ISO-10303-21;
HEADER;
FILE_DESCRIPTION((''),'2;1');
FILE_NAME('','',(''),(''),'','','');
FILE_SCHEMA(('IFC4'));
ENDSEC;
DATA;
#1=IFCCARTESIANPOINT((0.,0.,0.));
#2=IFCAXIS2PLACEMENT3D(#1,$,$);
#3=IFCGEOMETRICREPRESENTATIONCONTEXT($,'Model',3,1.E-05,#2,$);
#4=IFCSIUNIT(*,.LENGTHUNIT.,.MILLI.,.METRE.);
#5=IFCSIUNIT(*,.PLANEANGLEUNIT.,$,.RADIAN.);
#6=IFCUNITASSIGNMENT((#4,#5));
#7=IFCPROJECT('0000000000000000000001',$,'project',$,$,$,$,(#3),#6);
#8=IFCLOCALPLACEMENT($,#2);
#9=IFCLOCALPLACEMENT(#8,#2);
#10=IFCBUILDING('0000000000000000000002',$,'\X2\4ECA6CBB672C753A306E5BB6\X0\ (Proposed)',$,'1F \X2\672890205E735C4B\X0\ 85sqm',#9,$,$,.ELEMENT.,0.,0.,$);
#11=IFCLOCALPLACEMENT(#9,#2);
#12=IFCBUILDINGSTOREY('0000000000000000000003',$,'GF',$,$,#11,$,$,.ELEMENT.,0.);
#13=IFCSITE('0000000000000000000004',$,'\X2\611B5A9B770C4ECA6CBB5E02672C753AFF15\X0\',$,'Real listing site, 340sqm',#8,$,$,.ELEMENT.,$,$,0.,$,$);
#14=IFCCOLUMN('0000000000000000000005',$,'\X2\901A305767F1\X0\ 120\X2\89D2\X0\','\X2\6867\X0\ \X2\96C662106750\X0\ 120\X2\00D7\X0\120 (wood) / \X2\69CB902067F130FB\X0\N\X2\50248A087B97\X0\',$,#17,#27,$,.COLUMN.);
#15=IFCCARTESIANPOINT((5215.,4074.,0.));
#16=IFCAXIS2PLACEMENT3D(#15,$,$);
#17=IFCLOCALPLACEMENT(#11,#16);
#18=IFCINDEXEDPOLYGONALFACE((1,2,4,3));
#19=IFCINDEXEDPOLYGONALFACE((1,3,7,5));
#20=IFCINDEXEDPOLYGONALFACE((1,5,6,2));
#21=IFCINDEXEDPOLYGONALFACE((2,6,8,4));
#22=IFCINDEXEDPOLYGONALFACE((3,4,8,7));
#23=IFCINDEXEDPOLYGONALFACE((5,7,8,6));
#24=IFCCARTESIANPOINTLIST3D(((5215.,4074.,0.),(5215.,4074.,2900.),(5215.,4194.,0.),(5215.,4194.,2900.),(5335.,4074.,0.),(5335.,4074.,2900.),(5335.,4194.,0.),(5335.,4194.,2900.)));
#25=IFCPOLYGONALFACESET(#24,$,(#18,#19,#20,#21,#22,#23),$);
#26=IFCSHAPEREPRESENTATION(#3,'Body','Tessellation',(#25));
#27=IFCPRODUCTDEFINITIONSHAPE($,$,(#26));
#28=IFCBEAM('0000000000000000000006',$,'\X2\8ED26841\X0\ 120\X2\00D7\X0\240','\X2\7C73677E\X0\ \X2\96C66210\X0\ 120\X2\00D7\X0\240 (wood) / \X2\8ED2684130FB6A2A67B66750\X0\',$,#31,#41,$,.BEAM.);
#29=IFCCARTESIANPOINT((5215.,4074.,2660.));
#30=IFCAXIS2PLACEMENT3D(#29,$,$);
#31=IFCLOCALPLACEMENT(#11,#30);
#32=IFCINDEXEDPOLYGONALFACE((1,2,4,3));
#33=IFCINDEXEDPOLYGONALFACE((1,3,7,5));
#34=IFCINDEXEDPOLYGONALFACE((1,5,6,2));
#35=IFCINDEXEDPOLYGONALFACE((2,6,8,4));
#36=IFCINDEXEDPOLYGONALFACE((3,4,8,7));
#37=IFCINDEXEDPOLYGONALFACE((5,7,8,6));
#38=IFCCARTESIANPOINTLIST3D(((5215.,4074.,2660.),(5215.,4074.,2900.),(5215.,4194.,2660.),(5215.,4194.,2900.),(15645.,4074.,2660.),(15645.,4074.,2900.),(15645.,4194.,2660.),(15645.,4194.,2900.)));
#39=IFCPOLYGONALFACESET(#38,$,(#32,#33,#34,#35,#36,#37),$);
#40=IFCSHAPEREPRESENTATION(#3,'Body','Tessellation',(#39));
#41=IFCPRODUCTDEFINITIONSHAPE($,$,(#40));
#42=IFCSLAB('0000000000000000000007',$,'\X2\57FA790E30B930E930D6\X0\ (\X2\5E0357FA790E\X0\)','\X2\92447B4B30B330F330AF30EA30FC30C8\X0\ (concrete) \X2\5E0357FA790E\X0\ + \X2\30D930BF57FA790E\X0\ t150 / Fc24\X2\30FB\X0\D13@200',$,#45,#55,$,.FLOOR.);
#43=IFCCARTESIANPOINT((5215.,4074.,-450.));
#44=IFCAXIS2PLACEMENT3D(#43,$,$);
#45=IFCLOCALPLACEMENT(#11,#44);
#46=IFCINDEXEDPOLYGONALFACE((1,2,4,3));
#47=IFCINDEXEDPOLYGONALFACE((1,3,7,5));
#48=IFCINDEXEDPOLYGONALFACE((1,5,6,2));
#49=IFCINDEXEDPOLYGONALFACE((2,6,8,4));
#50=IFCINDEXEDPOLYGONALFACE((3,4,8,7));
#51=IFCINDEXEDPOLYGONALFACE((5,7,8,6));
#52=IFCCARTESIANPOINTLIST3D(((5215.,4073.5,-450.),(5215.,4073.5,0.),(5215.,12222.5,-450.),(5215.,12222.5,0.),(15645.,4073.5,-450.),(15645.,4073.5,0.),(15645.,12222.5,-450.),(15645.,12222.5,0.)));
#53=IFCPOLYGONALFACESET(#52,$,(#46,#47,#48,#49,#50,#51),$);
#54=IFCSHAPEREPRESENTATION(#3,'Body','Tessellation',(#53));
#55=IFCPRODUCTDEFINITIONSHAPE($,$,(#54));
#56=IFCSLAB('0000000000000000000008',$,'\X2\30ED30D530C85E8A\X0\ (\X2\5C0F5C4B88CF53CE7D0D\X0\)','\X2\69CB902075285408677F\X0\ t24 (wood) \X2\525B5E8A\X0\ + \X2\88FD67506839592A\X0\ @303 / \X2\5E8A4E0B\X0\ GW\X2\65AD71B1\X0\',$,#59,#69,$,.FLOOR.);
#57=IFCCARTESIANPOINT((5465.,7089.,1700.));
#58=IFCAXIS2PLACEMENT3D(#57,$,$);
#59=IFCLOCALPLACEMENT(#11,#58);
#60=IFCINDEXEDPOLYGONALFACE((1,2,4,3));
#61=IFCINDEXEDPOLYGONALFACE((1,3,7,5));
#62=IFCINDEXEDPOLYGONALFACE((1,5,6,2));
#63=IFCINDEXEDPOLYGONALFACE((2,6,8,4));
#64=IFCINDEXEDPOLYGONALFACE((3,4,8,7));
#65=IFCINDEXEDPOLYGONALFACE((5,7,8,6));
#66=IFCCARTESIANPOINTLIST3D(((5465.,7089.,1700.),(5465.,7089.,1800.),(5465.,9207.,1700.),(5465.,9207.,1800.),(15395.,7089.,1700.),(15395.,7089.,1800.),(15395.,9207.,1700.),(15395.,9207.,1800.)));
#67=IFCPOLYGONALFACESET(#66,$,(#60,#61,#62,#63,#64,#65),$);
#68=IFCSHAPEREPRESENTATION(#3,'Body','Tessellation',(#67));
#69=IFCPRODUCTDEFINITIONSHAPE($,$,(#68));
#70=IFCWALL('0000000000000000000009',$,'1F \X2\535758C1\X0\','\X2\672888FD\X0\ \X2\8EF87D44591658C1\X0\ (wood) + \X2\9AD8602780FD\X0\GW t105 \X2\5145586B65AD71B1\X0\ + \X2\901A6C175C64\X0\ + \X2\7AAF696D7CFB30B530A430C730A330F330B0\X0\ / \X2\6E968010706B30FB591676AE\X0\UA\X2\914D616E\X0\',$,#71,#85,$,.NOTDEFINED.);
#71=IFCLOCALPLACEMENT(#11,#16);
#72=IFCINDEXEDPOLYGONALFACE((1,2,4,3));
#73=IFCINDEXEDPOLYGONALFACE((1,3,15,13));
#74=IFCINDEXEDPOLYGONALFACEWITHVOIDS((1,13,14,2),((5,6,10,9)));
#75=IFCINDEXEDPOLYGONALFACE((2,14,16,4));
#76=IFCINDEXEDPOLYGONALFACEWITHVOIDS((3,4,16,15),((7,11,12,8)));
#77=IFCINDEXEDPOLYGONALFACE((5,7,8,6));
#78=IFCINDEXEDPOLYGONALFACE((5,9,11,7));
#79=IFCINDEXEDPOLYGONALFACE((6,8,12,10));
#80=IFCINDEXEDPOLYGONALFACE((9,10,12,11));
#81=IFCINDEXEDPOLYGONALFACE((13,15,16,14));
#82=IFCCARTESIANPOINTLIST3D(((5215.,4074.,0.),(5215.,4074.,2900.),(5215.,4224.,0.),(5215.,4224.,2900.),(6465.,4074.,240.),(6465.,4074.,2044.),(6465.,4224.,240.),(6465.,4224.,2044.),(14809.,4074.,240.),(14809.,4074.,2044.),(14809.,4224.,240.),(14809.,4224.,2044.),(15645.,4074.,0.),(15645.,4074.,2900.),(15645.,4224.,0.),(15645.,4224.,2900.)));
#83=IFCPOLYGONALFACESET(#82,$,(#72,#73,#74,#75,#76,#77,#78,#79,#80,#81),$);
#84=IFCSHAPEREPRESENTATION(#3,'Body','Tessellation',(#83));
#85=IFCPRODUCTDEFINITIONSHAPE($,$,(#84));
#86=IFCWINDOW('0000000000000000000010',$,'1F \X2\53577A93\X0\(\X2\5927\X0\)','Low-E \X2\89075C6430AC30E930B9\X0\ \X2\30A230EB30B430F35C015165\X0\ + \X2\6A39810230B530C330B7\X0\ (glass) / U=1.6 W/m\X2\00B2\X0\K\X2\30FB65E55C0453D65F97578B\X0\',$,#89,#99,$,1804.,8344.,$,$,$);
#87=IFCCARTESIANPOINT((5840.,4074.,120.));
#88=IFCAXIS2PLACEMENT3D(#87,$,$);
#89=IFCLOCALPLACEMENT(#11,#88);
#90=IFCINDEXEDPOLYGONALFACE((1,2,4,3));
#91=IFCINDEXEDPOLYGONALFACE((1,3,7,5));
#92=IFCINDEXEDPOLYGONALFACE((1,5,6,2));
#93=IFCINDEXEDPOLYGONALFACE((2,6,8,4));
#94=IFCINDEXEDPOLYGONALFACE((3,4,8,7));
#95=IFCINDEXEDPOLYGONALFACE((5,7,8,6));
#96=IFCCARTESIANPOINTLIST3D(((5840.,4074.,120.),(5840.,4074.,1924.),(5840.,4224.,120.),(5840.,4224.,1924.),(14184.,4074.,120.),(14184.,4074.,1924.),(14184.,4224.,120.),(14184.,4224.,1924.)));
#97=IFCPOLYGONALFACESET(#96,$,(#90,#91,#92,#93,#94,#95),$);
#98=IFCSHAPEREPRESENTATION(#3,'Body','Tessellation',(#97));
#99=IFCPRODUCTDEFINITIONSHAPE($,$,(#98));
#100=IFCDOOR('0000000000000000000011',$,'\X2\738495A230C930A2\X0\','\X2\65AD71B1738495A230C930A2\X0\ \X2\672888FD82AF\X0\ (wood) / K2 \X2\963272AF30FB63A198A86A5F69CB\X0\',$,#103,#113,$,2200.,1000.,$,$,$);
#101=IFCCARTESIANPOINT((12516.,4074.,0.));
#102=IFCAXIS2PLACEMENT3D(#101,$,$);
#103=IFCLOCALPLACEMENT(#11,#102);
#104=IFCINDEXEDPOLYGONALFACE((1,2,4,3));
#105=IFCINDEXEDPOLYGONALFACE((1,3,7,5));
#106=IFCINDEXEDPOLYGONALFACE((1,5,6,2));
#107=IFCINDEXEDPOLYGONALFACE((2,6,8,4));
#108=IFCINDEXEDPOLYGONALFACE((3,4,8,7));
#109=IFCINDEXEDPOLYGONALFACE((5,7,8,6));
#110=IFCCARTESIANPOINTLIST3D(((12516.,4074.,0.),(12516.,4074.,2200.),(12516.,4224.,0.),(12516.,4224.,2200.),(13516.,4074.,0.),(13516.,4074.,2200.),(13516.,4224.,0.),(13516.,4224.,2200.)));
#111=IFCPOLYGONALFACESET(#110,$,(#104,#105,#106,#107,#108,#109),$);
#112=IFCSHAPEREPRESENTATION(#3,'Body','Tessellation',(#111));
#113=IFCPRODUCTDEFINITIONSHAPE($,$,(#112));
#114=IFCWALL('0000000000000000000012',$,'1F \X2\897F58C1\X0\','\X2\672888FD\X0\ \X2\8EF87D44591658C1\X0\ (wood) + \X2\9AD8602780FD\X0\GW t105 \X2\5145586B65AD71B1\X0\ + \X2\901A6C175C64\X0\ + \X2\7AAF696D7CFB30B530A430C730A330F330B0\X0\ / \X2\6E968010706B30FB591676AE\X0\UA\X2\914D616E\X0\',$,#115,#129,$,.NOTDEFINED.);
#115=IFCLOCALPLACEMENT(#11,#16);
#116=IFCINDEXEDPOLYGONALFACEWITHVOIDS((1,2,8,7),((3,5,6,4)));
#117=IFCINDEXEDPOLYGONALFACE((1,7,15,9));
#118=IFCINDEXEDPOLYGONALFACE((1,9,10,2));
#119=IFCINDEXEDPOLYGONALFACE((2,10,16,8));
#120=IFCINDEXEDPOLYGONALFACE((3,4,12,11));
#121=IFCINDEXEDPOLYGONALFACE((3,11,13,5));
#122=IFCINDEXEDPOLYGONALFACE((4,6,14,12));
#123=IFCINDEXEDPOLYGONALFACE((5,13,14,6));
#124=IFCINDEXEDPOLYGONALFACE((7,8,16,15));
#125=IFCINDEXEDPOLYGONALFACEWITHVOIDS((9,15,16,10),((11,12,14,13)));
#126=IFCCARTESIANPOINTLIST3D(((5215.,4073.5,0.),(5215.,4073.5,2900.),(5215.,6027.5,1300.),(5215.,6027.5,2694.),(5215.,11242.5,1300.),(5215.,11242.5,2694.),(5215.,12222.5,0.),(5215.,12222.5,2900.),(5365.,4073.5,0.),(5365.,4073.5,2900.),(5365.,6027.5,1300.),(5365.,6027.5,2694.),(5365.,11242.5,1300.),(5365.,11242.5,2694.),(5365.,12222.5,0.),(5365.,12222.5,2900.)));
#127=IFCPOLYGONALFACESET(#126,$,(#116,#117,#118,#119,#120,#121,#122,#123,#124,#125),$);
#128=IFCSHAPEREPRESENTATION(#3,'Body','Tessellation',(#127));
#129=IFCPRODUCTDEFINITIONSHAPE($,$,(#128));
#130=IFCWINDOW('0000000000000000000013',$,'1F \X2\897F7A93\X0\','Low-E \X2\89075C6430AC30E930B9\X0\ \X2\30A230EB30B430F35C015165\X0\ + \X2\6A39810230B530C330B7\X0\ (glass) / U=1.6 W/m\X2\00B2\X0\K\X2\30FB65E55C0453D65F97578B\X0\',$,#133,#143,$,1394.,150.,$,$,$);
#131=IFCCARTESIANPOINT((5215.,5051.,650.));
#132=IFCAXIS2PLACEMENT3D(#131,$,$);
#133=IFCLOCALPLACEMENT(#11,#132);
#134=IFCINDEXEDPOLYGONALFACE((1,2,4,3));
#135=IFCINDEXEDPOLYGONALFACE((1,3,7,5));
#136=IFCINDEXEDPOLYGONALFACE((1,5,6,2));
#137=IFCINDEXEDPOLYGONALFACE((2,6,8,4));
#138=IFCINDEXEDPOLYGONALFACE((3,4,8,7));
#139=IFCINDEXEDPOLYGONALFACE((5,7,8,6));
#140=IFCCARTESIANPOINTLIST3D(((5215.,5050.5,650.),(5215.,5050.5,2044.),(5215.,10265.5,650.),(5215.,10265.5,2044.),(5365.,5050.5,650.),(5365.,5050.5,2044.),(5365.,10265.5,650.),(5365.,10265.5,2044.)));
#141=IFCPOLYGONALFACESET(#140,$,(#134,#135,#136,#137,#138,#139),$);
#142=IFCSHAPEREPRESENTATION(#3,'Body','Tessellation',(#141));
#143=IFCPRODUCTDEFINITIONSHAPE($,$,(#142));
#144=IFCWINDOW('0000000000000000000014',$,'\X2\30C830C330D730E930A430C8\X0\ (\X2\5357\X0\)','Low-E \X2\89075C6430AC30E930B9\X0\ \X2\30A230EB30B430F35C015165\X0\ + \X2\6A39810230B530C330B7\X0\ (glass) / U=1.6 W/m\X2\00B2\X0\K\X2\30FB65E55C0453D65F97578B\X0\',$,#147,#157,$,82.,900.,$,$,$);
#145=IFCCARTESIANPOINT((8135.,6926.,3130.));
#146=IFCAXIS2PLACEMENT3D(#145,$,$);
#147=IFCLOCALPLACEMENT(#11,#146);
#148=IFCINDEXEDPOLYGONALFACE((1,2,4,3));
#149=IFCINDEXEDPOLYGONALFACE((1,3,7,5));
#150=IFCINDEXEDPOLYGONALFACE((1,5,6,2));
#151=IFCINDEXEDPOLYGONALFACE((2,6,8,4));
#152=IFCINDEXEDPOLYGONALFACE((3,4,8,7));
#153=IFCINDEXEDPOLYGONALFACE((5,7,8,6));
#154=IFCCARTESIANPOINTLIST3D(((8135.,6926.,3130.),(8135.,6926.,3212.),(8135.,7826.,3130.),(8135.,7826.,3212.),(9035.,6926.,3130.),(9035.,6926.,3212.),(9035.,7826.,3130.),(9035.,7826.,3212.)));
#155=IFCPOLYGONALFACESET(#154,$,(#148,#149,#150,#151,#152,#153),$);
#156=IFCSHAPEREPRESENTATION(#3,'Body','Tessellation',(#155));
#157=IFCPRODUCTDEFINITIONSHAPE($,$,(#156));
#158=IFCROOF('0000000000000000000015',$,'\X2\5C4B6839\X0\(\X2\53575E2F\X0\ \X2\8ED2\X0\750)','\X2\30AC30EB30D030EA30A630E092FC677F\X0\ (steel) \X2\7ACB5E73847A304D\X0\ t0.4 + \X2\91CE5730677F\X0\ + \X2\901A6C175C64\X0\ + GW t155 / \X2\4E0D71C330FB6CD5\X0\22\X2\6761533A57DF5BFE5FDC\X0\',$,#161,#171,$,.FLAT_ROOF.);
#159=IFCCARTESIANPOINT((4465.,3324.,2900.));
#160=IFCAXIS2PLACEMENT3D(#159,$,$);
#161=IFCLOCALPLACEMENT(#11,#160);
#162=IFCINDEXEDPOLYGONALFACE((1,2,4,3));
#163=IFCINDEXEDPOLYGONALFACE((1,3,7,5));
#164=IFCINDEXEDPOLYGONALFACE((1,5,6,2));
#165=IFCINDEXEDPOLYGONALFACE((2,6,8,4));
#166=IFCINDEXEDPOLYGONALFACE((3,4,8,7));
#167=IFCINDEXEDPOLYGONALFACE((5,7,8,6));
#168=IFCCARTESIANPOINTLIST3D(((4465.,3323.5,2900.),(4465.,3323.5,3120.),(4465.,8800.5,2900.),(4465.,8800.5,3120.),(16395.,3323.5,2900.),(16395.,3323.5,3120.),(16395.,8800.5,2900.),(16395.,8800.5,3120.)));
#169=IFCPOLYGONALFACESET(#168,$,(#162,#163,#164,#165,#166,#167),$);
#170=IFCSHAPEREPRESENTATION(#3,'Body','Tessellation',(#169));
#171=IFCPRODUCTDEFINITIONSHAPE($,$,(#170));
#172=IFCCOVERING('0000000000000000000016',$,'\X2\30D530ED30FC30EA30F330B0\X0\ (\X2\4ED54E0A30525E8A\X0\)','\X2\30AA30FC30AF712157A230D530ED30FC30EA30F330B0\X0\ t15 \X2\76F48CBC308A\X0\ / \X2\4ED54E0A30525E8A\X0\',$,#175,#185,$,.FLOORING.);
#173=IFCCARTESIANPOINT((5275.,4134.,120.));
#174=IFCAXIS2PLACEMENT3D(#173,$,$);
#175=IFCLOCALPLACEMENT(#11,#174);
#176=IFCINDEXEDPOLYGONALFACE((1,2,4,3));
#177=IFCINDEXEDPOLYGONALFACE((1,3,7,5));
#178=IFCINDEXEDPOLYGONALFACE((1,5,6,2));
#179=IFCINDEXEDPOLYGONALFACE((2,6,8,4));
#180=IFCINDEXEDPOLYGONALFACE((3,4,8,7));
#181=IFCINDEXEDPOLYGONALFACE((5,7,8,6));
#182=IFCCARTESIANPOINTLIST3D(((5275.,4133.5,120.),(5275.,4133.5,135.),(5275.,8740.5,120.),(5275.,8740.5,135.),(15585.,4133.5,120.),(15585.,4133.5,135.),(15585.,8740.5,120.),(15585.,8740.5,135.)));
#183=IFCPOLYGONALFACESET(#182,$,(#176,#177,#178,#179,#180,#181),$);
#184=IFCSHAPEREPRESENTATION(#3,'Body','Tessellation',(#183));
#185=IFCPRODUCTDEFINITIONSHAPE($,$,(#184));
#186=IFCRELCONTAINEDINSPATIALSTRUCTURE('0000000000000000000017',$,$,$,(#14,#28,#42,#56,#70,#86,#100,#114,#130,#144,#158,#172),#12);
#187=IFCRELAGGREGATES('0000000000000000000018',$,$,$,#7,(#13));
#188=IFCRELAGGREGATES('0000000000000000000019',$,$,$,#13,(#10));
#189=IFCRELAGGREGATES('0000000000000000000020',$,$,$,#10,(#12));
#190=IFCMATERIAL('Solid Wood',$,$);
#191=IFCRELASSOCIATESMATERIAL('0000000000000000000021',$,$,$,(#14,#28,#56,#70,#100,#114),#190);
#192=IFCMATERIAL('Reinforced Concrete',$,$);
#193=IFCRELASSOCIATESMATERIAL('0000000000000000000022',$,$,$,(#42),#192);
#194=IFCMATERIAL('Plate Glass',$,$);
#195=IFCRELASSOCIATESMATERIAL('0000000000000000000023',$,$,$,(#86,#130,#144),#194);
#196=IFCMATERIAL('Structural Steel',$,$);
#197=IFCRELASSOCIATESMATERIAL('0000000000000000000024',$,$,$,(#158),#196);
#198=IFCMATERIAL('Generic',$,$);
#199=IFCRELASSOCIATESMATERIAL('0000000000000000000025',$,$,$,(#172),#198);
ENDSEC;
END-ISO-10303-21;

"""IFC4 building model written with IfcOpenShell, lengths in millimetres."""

from ifc_helpers import new_model, si_unit, frame, frame_2d, origin, place, context, project, spatial, rectangle, extrude, material, element, fill, save


model = new_model("IFC4")

# Units and contexts
model_context = context("Model", 3, precision=1e-05, world=origin())
ifc_project = project(units=[si_unit("LENGTHUNIT", "METRE", prefix="MILLI"), si_unit("PLANEANGLEUNIT", "RADIAN")], contexts=[model_context])

# Site, building, storey
site_placement = place(None, origin())
site = spatial("IfcSite", under=ifc_project, at=site_placement, Name="愛媛県今治市本町５", ObjectType="Real listing site, 340sqm", CompositionType="ELEMENT", RefElevation=0.0)
building_placement = place(site_placement, origin())
building = spatial("IfcBuilding", under=site, at=building_placement, Name="今治本町の家 (Proposed)", ObjectType="1F 木造平屋 85sqm", CompositionType="ELEMENT", ElevationOfRefHeight=0.0, ElevationOfTerrain=0.0)
storey_placement = place(building_placement, origin())
storey = spatial("IfcBuildingStorey", under=building, at=storey_placement, Name="GF", CompositionType="ELEMENT", Elevation=0.0)

# Column
ifc_material_1 = material(Name="Solid Wood")
column_1_placement = place(storey_placement, frame((5215.0, 4074.0, 0.0)))
element("IfcColumn", 1, at=column_1_placement, inside=storey, material=ifc_material_1, Name="通し柱 120角", Description="桧 集成材 120×120 (wood) / 構造柱・N値計算", PredefinedType="COLUMN", context=model_context, shape_type="SweptSolid", body=[
    extrude(rectangle(XDim=120.0, YDim=120.0, at=frame_2d((60.0, 60.0))), frame((5215.0, 4074.0, 0.0)), (0.0, 0.0, 1.0), 2900.0),
])

# Beam
beam_1_placement = place(storey_placement, frame((5215.0, 4074.0, 2660.0)))
element("IfcBeam", 2, at=beam_1_placement, inside=storey, material=ifc_material_1, Name="軒桁 120×240", Description="米松 集成 120×240 (wood) / 軒桁・横架材", PredefinedType="BEAM", context=model_context, shape_type="SweptSolid", body=[
    extrude(rectangle(XDim=10430.0, YDim=120.0, at=frame_2d((5215.0, 60.0))), frame((5215.0, 4074.0, 2660.0)), (0.0, 0.0, 1.0), 240.0),
])

# Slabs
ifc_material_2 = material(Name="Reinforced Concrete")
slab_1_placement = place(storey_placement, frame((5215.0, 4074.0, -450.0)))
element("IfcSlab", 3, at=slab_1_placement, inside=storey, material=ifc_material_2, Name="基礎スラブ (布基礎)", Description="鉄筋コンクリート (concrete) 布基礎 + ベタ基礎 t150 / Fc24・D13@200", PredefinedType="FLOOR", context=model_context, shape_type="SweptSolid", body=[
    extrude(rectangle(XDim=10430.0, YDim=8149.0, at=frame_2d((5215.0, 4074.0))), frame((5215.0, 4074.0, -450.0)), (0.0, 0.0, 1.0), 450.0),
])
slab_2_placement = place(storey_placement, frame((5465.0, 7089.0, 1700.0)))
element("IfcSlab", 4, at=slab_2_placement, inside=storey, material=ifc_material_1, Name="ロフト床 (小屋裏収納)", Description="構造用合板 t24 (wood) 剛床 + 製材根太 @303 / 床下 GW断熱", PredefinedType="FLOOR", context=model_context, shape_type="SweptSolid", body=[
    extrude(rectangle(XDim=9930.0, YDim=2118.0, at=frame_2d((4965.0, 1059.0))), frame((5465.0, 7089.0, 1700.0)), (0.0, 0.0, 1.0), 100.0),
])

# Wall, openings, window, door
wall_1_placement = place(storey_placement, frame((5215.0, 4074.0, 0.0)))
wall_1 = element("IfcWall", 5, at=wall_1_placement, inside=storey, material=ifc_material_1, Name="1F 南壁", Description="木製 軸組外壁 (wood) + 高性能GW t105 充填断熱 + 通気層 + 窯業系サイディング / 準耐火・外皮UA配慮", PredefinedType="NOTDEFINED", context=model_context, shape_type="SweptSolid", body=[
    extrude(rectangle(XDim=10430.0, YDim=150.0, at=frame_2d((5215.0, 75.0))), frame((5215.0, 4074.0, 0.0)), (0.0, 0.0, 1.0), 2900.0),
])
opening_1_placement = place(storey_placement, frame((5840.0, 4074.0, 120.0)))
opening_1 = element("IfcOpeningElement", 6, at=opening_1_placement, cuts=wall_1, PredefinedType="NOTDEFINED", context=model_context, shape_type="SweptSolid", body=[
    extrude(rectangle(XDim=8344.0, YDim=150.0, at=frame_2d((4172.0, 75.0))), frame((5840.0, 4074.0, 120.0)), (0.0, 0.0, 1.0), 1804.0),
])
opening_2_placement = place(storey_placement, frame((12516.0, 4074.0, 0.0)))
opening_2 = element("IfcOpeningElement", 7, at=opening_2_placement, cuts=wall_1, PredefinedType="NOTDEFINED", context=model_context, shape_type="SweptSolid", body=[
    extrude(rectangle(XDim=1000.0, YDim=150.0, at=frame_2d((500.0, 75.0))), frame((12516.0, 4074.0, 0.0)), (0.0, 0.0, 1.0), 2200.0),
])
ifc_material_3 = material(Name="Plate Glass")
window_1_placement = place(storey_placement, frame((5840.0, 4074.0, 120.0)))
window_1 = element("IfcWindow", 8, at=window_1_placement, inside=storey, material=ifc_material_3, Name="1F 南窓(大)", Description="Low-E 複層ガラス アルゴン封入 + 樹脂サッシ (glass) / U=1.6 W/m²K・日射取得型", OverallHeight=1804.0, OverallWidth=8344.0, context=model_context, shape_type="SweptSolid", body=[
    extrude(rectangle(XDim=8344.0, YDim=150.0, at=frame_2d((4172.0, 75.0))), frame((5840.0, 4074.0, 120.0)), (0.0, 0.0, 1.0), 1804.0),
])
fill(opening_1, window_1)
door_placement = place(storey_placement, frame((12516.0, 4074.0, 0.0)))
door = element("IfcDoor", 9, at=door_placement, inside=storey, material=ifc_material_1, Name="玄関ドア", Description="断熱玄関ドア 木製芯 (wood) / K2 防犯・採風機構", OverallHeight=2200.0, OverallWidth=1000.0, context=model_context, shape_type="SweptSolid", body=[
    extrude(rectangle(XDim=1000.0, YDim=150.0, at=frame_2d((500.0, 75.0))), frame((12516.0, 4074.0, 0.0)), (0.0, 0.0, 1.0), 2200.0),
])
fill(opening_2, door)

# Wall, opening, window
wall_2_placement = place(storey_placement, frame((5215.0, 4074.0, 0.0)))
wall_2 = element("IfcWall", 10, at=wall_2_placement, inside=storey, material=ifc_material_1, Name="1F 西壁", Description="木製 軸組外壁 (wood) + 高性能GW t105 充填断熱 + 通気層 + 窯業系サイディング / 準耐火・外皮UA配慮", PredefinedType="NOTDEFINED", context=model_context, shape_type="SweptSolid", body=[
    extrude(rectangle(XDim=150.0, YDim=8149.0, at=frame_2d((75.0, 4074.0))), frame((5215.0, 4074.0, 0.0)), (0.0, 0.0, 1.0), 2900.0),
])
opening_3_placement = place(storey_placement, frame((5215.0, 5051.0, 650.0)))
opening_3 = element("IfcOpeningElement", 11, at=opening_3_placement, cuts=wall_2, PredefinedType="NOTDEFINED", context=model_context, shape_type="SweptSolid", body=[
    extrude(rectangle(XDim=150.0, YDim=5215.0, at=frame_2d((75.0, 2607.0))), frame((5215.0, 5051.0, 650.0)), (0.0, 0.0, 1.0), 1394.0),
])
window_2_placement = place(storey_placement, frame((5215.0, 5051.0, 650.0)))
window_2 = element("IfcWindow", 12, at=window_2_placement, inside=storey, material=ifc_material_3, Name="1F 西窓", Description="Low-E 複層ガラス アルゴン封入 + 樹脂サッシ (glass) / U=1.6 W/m²K・日射取得型", OverallHeight=1394.0, OverallWidth=150.0, context=model_context, shape_type="SweptSolid", body=[
    extrude(rectangle(XDim=150.0, YDim=5215.0, at=frame_2d((75.0, 2607.0))), frame((5215.0, 5051.0, 650.0)), (0.0, 0.0, 1.0), 1394.0),
])
fill(opening_3, window_2)

# Window
window_3_placement = place(storey_placement, frame((8135.0, 6926.0, 3130.0)))
element("IfcWindow", 13, at=window_3_placement, inside=storey, material=ifc_material_3, Name="トップライト (南)", Description="Low-E 複層ガラス アルゴン封入 + 樹脂サッシ (glass) / U=1.6 W/m²K・日射取得型", OverallHeight=82.0, OverallWidth=900.0, context=model_context, shape_type="SweptSolid", body=[
    extrude(rectangle(XDim=900.0, YDim=900.0, at=frame_2d((450.0, 450.0))), frame((8135.0, 6926.0, 3130.0)), (0.0, 0.0, 1.0), 82.0),
])

# Roof
ifc_material_4 = material(Name="Structural Steel")
roof_placement = place(storey_placement, frame((4465.0, 3324.0, 2900.0)))
element("IfcRoof", 14, at=roof_placement, inside=storey, material=ifc_material_4, Name="屋根(南帯 軒750)", Description="ガルバリウム鋼板 (steel) 立平葺き t0.4 + 野地板 + 通気層 + GW t155 / 不燃・法22条区域対応", PredefinedType="FLAT_ROOF", context=model_context, shape_type="SweptSolid", body=[
    extrude(rectangle(XDim=11930.0, YDim=5477.0, at=frame_2d((5965.0, 2738.0))), frame((4465.0, 3324.0, 2900.0)), (0.0, 0.0, 1.0), 220.0),
])

# Covering
ifc_material_5 = material(Name="Generic")
covering_1_placement = place(storey_placement, frame((5275.0, 4134.0, 120.0)))
element("IfcCovering", 15, at=covering_1_placement, inside=storey, material=ifc_material_5, Name="フローリング (仕上げ床)", Description="オーク無垢フローリング t15 直貼り / 仕上げ床", PredefinedType="FLOORING", context=model_context, shape_type="SweptSolid", body=[
    extrude(rectangle(XDim=10310.0, YDim=4607.0, at=frame_2d((5155.0, 2303.0))), frame((5275.0, 4134.0, 120.0)), (0.0, 0.0, 1.0), 15.0),
])

save(model, "model.ifc")
